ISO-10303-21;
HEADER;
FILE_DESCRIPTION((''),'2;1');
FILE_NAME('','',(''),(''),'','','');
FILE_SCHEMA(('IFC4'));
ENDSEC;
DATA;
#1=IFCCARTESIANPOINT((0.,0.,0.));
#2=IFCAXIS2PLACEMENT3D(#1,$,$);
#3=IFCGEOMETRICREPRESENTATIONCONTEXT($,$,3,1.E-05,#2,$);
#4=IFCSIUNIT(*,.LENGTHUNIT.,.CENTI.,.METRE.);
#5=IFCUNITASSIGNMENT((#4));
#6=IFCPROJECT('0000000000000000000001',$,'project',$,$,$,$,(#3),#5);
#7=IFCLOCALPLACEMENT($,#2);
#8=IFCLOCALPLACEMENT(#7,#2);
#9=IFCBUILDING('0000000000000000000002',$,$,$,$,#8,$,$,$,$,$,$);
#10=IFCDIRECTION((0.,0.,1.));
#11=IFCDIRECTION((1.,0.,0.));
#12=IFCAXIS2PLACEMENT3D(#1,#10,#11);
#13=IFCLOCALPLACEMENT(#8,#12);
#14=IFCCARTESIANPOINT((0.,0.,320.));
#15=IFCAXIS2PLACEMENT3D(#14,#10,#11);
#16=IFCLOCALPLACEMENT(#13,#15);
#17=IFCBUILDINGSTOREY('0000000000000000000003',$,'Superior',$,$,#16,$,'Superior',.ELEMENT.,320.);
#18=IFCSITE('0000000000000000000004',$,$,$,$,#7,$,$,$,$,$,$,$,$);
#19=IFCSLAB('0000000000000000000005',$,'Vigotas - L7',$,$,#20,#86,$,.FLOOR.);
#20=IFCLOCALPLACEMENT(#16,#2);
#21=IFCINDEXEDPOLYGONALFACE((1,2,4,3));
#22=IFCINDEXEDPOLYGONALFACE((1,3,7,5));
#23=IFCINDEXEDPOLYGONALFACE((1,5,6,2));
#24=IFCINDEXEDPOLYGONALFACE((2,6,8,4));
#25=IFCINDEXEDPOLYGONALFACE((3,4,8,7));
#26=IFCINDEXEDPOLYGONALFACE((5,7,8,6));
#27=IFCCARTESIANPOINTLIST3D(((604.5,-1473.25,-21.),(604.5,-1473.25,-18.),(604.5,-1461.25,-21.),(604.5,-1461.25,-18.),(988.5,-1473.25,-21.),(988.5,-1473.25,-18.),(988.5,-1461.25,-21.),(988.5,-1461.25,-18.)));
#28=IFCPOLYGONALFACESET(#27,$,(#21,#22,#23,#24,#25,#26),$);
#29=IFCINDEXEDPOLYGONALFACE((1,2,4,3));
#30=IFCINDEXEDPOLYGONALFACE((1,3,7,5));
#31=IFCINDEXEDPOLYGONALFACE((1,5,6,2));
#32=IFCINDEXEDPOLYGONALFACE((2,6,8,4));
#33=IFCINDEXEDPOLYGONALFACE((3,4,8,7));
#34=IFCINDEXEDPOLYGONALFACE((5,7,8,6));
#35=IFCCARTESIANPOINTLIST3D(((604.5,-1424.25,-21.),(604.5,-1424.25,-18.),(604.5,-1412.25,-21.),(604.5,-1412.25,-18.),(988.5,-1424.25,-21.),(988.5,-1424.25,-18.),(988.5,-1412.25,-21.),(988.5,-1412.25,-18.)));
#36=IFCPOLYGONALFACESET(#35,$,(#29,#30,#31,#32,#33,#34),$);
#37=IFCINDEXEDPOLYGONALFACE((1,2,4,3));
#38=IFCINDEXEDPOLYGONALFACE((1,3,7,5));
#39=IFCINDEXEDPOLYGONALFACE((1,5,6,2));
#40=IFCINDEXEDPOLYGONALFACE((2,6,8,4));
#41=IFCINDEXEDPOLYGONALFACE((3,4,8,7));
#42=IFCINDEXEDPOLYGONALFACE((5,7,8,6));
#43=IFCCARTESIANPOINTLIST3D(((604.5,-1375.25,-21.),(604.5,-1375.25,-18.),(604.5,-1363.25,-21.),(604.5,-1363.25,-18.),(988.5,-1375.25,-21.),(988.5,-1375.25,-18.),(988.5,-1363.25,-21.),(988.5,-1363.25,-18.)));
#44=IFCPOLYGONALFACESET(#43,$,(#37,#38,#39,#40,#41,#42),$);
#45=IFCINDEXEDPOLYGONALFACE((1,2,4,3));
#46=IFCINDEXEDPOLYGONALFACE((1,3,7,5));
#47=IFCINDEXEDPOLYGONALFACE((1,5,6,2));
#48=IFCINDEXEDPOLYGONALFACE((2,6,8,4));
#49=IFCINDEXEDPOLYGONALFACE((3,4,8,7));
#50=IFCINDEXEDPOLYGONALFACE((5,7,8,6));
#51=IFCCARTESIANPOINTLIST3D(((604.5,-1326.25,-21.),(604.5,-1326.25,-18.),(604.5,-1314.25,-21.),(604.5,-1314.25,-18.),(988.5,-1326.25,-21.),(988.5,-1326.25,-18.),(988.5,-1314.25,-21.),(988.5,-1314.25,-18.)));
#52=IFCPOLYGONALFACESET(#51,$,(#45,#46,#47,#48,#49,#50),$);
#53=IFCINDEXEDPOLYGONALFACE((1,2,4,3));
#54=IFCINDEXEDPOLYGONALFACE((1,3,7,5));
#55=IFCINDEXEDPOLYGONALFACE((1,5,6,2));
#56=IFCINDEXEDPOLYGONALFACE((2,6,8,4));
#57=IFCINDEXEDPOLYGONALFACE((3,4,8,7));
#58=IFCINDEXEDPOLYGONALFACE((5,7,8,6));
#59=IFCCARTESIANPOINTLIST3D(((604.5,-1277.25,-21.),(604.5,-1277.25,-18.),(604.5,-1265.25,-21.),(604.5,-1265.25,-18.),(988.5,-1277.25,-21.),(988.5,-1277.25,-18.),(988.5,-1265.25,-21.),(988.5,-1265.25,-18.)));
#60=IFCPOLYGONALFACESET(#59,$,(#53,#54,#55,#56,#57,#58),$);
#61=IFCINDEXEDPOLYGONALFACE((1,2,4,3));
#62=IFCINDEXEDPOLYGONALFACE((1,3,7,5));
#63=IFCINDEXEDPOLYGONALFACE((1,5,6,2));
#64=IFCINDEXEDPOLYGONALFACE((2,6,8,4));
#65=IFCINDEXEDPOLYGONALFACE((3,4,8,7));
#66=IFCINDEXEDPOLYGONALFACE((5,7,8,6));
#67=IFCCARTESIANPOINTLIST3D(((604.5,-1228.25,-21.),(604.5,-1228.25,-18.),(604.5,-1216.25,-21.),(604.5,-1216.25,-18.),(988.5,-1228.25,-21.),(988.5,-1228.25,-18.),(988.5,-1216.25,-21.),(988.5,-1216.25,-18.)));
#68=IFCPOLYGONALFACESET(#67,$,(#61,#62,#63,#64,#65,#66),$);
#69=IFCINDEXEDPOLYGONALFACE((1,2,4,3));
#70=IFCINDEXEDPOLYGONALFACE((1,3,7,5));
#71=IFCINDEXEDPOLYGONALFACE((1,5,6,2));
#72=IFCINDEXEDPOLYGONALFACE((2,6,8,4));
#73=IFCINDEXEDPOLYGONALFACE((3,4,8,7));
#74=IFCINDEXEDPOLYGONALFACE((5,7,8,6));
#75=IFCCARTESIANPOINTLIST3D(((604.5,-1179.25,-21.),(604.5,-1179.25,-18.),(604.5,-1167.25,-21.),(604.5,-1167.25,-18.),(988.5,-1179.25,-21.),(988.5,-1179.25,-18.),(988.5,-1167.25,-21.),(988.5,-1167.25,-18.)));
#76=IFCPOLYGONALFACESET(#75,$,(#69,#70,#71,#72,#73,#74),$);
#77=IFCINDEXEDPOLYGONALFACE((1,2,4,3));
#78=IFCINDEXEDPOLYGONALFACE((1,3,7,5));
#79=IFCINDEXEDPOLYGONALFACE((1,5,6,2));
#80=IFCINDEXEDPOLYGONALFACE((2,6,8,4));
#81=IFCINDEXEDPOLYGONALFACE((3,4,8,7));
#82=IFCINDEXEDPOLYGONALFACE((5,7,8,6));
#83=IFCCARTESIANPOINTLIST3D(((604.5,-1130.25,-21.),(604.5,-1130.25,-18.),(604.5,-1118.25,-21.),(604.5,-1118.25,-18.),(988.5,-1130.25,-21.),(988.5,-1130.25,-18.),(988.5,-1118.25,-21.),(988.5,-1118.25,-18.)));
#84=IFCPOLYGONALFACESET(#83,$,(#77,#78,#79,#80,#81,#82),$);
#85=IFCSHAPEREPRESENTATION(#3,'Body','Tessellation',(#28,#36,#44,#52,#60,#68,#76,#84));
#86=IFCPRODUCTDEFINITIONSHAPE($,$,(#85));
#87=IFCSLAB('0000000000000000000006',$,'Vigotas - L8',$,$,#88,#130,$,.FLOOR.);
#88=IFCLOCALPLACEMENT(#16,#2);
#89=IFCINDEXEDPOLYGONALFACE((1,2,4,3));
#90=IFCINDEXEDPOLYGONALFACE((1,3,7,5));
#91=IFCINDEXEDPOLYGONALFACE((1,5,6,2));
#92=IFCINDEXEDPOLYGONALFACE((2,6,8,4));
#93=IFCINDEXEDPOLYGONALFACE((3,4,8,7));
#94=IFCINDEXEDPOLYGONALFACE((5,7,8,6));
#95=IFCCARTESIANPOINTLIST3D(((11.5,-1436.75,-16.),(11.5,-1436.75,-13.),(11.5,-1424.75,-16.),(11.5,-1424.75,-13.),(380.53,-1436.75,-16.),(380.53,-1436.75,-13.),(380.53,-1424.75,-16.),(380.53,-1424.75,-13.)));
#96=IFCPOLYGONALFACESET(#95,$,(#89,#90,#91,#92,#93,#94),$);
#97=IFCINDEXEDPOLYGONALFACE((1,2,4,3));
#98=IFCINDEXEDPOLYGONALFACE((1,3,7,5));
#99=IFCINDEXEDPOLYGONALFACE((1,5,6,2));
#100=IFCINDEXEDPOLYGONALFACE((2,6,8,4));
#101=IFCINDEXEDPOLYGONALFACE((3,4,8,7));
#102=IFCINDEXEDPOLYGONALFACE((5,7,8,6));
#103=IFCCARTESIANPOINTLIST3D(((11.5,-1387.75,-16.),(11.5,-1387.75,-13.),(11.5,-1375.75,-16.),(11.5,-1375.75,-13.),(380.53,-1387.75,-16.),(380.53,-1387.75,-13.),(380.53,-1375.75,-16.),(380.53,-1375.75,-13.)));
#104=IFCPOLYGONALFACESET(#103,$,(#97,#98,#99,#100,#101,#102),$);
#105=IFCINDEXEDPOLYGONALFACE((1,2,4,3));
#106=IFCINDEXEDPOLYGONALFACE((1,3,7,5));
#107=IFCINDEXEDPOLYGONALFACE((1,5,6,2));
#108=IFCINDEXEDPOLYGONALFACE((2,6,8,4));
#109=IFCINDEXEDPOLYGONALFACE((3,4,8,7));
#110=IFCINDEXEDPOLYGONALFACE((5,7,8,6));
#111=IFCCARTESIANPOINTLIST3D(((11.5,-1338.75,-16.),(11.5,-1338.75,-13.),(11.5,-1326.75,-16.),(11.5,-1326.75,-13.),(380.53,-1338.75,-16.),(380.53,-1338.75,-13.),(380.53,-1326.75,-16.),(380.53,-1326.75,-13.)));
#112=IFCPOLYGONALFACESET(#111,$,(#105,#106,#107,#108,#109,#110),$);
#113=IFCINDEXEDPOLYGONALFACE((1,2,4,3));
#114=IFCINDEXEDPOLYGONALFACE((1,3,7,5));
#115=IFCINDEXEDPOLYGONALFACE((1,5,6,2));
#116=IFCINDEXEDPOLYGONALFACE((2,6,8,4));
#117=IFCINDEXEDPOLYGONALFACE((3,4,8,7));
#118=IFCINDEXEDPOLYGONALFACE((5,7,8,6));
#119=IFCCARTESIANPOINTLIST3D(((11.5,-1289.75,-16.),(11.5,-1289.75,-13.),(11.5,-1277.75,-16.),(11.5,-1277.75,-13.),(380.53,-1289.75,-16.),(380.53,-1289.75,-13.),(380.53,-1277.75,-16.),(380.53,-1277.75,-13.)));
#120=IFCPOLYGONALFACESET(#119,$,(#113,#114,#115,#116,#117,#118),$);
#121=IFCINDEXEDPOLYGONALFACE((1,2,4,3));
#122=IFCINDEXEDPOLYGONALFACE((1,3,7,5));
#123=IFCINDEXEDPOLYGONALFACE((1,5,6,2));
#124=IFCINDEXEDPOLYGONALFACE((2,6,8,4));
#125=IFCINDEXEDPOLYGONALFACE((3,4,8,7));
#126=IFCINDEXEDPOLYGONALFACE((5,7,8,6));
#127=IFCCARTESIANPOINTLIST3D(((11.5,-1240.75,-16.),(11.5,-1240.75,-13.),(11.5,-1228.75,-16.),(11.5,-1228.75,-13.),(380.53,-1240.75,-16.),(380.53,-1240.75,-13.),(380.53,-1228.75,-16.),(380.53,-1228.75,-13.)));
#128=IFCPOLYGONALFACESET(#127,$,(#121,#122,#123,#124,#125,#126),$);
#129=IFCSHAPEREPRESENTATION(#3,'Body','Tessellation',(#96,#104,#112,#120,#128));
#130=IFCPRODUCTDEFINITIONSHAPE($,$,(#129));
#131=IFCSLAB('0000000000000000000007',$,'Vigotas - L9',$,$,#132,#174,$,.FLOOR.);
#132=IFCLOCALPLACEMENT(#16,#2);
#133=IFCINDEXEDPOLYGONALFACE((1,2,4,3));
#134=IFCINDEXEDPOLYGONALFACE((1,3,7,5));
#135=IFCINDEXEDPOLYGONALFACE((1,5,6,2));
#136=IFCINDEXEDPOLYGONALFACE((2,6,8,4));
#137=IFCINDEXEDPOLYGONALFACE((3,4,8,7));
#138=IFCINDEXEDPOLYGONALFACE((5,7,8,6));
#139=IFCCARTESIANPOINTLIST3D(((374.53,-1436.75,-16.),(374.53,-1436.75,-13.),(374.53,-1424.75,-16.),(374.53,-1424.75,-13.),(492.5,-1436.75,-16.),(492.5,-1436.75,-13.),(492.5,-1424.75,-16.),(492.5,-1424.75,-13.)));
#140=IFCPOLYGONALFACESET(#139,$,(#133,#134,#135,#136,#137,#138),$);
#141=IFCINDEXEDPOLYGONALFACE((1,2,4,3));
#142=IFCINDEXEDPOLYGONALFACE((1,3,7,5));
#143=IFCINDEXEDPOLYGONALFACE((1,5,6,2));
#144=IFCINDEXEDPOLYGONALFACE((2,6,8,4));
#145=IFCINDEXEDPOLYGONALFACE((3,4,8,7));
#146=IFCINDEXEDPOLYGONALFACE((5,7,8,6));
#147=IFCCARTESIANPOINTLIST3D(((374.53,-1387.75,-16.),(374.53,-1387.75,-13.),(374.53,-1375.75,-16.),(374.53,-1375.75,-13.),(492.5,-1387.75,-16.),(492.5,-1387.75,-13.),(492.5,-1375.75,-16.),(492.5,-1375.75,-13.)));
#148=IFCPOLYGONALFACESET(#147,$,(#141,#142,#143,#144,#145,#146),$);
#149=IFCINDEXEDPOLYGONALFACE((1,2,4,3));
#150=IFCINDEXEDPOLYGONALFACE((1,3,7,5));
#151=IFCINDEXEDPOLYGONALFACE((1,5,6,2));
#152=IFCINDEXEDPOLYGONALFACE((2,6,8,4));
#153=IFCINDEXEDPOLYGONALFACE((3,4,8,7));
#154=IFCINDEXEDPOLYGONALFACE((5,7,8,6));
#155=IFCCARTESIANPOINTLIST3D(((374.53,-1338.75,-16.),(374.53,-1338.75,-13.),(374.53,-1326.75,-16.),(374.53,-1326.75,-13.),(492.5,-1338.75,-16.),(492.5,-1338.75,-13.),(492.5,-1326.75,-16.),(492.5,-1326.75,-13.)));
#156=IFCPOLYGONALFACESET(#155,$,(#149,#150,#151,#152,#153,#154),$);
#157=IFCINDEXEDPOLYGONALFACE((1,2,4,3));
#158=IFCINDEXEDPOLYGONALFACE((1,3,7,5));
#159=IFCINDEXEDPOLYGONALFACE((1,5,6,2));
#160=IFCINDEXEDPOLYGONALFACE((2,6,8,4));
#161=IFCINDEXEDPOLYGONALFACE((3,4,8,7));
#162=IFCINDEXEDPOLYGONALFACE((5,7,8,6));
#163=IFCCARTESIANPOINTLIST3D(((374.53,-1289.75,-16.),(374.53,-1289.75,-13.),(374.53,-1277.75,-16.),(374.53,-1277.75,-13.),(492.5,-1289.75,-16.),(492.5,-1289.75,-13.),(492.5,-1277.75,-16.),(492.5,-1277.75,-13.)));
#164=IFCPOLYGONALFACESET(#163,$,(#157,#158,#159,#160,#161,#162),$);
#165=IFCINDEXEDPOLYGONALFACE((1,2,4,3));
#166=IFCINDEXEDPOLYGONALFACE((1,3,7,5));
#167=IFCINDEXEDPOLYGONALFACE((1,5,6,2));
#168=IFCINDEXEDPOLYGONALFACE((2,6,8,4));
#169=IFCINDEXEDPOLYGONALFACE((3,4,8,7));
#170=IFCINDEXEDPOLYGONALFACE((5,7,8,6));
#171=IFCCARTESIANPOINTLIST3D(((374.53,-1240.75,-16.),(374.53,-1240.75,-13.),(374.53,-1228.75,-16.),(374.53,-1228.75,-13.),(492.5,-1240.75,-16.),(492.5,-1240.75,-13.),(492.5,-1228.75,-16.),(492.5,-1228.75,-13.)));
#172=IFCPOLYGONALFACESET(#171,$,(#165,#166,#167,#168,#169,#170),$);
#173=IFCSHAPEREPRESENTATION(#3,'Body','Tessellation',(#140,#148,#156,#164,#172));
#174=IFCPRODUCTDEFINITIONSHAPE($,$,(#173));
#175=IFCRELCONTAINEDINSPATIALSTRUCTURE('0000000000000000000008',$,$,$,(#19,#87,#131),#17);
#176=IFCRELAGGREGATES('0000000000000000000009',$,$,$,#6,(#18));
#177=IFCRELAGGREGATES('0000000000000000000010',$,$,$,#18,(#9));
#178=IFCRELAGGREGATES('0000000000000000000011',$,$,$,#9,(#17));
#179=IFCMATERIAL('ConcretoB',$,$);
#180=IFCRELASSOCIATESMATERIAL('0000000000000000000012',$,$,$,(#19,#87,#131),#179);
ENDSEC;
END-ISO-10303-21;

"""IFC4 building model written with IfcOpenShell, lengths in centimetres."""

from ifc_helpers import new_model, si_unit, frame, origin, origin_with_axes, place, context, project, spatial, polyline, outline, extrude, material, element, save


model = new_model("IFC4")

# Units and contexts
context_of_model = context(None, 3, precision=1e-05, world=origin())
ifc_project = project(units=[si_unit("LENGTHUNIT", "METRE", prefix="CENTI")], contexts=[context_of_model])

# Site, building, storey
site_placement = place(None, origin())
site = spatial("IfcSite", under=ifc_project, at=site_placement)
building_placement = place(site_placement, origin())
building = spatial("IfcBuilding", under=site, at=building_placement)
placement = place(building_placement, origin_with_axes())
storey_placement = place(placement, frame((0.0, 0.0, 320.0), z_axis=(0.0, 0.0, 1.0), x_axis=(1.0, 0.0, 0.0)))
storey = spatial("IfcBuildingStorey", under=building, at=storey_placement, Name="Superior", LongName="Superior", CompositionType="ELEMENT", Elevation=320.0)

# Shared definitions
ifc_material = material(Name="ConcretoB")

# Slabs
slab_1_placement = place(storey_placement, frame((796.5, -1295.75, -18.0), z_axis=(0.0, 0.0, 1.0), x_axis=(1.0, 0.0, 0.0)))
element("IfcSlab", 1, at=slab_1_placement, inside=storey, material=ifc_material, Name="Vigotas - L7", PredefinedType="FLOOR", context=context_of_model, shape_type="SolidModel", body=[
    extrude(outline(polyline([(6.0, 1.5), (-6.0, 1.5), (-6.0, -1.5), (6.0, -1.5), (6.0, 1.5), (6.0, 1.5)])), frame((-192.0, -171.5, -1.5), z_axis=(1.0, 0.0, 0.0), x_axis=(0.0, -1.0, 0.0)), (0.0, 0.0, 1.0), 384.0),
    extrude(outline(polyline([(6.0, 1.5), (-6.0, 1.5), (-6.0, -1.5), (6.0, -1.5), (6.0, 1.5), (6.0, 1.5)])), frame((-192.0, -122.5, -1.5), z_axis=(1.0, 0.0, 0.0), x_axis=(0.0, -1.0, 0.0)), (0.0, 0.0, 1.0), 384.0),
    extrude(outline(polyline([(6.0, 1.5), (-6.0, 1.5), (-6.0, -1.5), (6.0, -1.5), (6.0, 1.5), (6.0, 1.5)])), frame((-192.0, -73.5, -1.5), z_axis=(1.0, 0.0, 0.0), x_axis=(0.0, -1.0, 0.0)), (0.0, 0.0, 1.0), 384.0),
    extrude(outline(polyline([(6.0, 1.5), (-6.0, 1.5), (-6.0, -1.5), (6.0, -1.5), (6.0, 1.5), (6.0, 1.5)])), frame((-192.0, -24.5, -1.5), z_axis=(1.0, 0.0, 0.0), x_axis=(0.0, -1.0, 0.0)), (0.0, 0.0, 1.0), 384.0),
    extrude(outline(polyline([(6.0, 1.5), (-6.0, 1.5), (-6.0, -1.5), (6.0, -1.5), (6.0, 1.5), (6.0, 1.5)])), frame((-192.0, 24.5, -1.5), z_axis=(1.0, 0.0, 0.0), x_axis=(0.0, -1.0, 0.0)), (0.0, 0.0, 1.0), 384.0),
    extrude(outline(polyline([(6.0, 1.5), (-6.0, 1.5), (-6.0, -1.5), (6.0, -1.5), (6.0, 1.5), (6.0, 1.5)])), frame((-192.0, 73.5, -1.5), z_axis=(1.0, 0.0, 0.0), x_axis=(0.0, -1.0, 0.0)), (0.0, 0.0, 1.0), 384.0),
    extrude(outline(polyline([(6.0, 1.5), (-6.0, 1.5), (-6.0, -1.5), (6.0, -1.5), (6.0, 1.5), (6.0, 1.5)])), frame((-192.0, 122.5, -1.5), z_axis=(1.0, 0.0, 0.0), x_axis=(0.0, -1.0, 0.0)), (0.0, 0.0, 1.0), 384.0),
    extrude(outline(polyline([(6.0, 1.5), (-6.0, 1.5), (-6.0, -1.5), (6.0, -1.5), (6.0, 1.5), (6.0, 1.5)])), frame((-192.0, 171.5, -1.5), z_axis=(1.0, 0.0, 0.0), x_axis=(0.0, -1.0, 0.0)), (0.0, 0.0, 1.0), 384.0),
])
slab_2_placement = place(storey_placement, frame((196.01, -1332.75, -13.0), z_axis=(0.0, 0.0, 1.0), x_axis=(1.0, 0.0, 0.0)))
element("IfcSlab", 2, at=slab_2_placement, inside=storey, material=ifc_material, Name="Vigotas - L8", PredefinedType="FLOOR", context=context_of_model, shape_type="SolidModel", body=[
    extrude(outline(polyline([(6.0, 1.5), (-6.0, 1.5), (-6.0, -1.5), (6.0, -1.5), (6.0, 1.5), (6.0, 1.5)])), frame((-184.51, -98.0, -1.5), z_axis=(1.0, 0.0, 0.0), x_axis=(0.0, -1.0, 0.0)), (0.0, 0.0, 1.0), 369.03),
    extrude(outline(polyline([(6.0, 1.5), (-6.0, 1.5), (-6.0, -1.5), (6.0, -1.5), (6.0, 1.5), (6.0, 1.5)])), frame((-184.51, -49.0, -1.5), z_axis=(1.0, 0.0, 0.0), x_axis=(0.0, -1.0, 0.0)), (0.0, 0.0, 1.0), 369.03),
    extrude(outline(polyline([(6.0, 1.5), (-6.0, 1.5), (-6.0, -1.5), (6.0, -1.5), (6.0, 1.5), (6.0, 1.5)])), frame((-184.51, 0.0, -1.5), z_axis=(1.0, 0.0, 0.0), x_axis=(0.0, -1.0, 0.0)), (0.0, 0.0, 1.0), 369.03),
    extrude(outline(polyline([(6.0, 1.5), (-6.0, 1.5), (-6.0, -1.5), (6.0, -1.5), (6.0, 1.5), (6.0, 1.5)])), frame((-184.51, 49.0, -1.5), z_axis=(1.0, 0.0, 0.0), x_axis=(0.0, -1.0, 0.0)), (0.0, 0.0, 1.0), 369.03),
    extrude(outline(polyline([(6.0, 1.5), (-6.0, 1.5), (-6.0, -1.5), (6.0, -1.5), (6.0, 1.5), (6.0, 1.5)])), frame((-184.51, 98.0, -1.5), z_axis=(1.0, 0.0, 0.0), x_axis=(0.0, -1.0, 0.0)), (0.0, 0.0, 1.0), 369.03),
])
slab_3_placement = place(storey_placement, frame((433.51, -1332.75, -13.0), z_axis=(0.0, 0.0, 1.0), x_axis=(1.0, 0.0, 0.0)))
element("IfcSlab", 3, at=slab_3_placement, inside=storey, material=ifc_material, Name="Vigotas - L9", PredefinedType="FLOOR", context=context_of_model, shape_type="SolidModel", body=[
    extrude(outline(polyline([(6.0, 1.5), (-6.0, 1.5), (-6.0, -1.5), (6.0, -1.5), (6.0, 1.5), (6.0, 1.5)])), frame((-58.98, -98.0, -1.5), z_axis=(1.0, 0.0, 0.0), x_axis=(0.0, -1.0, 0.0)), (0.0, 0.0, 1.0), 117.97),
    extrude(outline(polyline([(6.0, 1.5), (-6.0, 1.5), (-6.0, -1.5), (6.0, -1.5), (6.0, 1.5), (6.0, 1.5)])), frame((-58.98, -49.0, -1.5), z_axis=(1.0, 0.0, 0.0), x_axis=(0.0, -1.0, 0.0)), (0.0, 0.0, 1.0), 117.97),
    extrude(outline(polyline([(6.0, 1.5), (-6.0, 1.5), (-6.0, -1.5), (6.0, -1.5), (6.0, 1.5), (6.0, 1.5)])), frame((-58.98, 0.0, -1.5), z_axis=(1.0, 0.0, 0.0), x_axis=(0.0, -1.0, 0.0)), (0.0, 0.0, 1.0), 117.97),
    extrude(outline(polyline([(6.0, 1.5), (-6.0, 1.5), (-6.0, -1.5), (6.0, -1.5), (6.0, 1.5), (6.0, 1.5)])), frame((-58.98, 49.0, -1.5), z_axis=(1.0, 0.0, 0.0), x_axis=(0.0, -1.0, 0.0)), (0.0, 0.0, 1.0), 117.97),
    extrude(outline(polyline([(6.0, 1.5), (-6.0, 1.5), (-6.0, -1.5), (6.0, -1.5), (6.0, 1.5), (6.0, 1.5)])), frame((-58.98, 98.0, -1.5), z_axis=(1.0, 0.0, 0.0), x_axis=(0.0, -1.0, 0.0)), (0.0, 0.0, 1.0), 117.97),
])

save(model, "model.ifc")
